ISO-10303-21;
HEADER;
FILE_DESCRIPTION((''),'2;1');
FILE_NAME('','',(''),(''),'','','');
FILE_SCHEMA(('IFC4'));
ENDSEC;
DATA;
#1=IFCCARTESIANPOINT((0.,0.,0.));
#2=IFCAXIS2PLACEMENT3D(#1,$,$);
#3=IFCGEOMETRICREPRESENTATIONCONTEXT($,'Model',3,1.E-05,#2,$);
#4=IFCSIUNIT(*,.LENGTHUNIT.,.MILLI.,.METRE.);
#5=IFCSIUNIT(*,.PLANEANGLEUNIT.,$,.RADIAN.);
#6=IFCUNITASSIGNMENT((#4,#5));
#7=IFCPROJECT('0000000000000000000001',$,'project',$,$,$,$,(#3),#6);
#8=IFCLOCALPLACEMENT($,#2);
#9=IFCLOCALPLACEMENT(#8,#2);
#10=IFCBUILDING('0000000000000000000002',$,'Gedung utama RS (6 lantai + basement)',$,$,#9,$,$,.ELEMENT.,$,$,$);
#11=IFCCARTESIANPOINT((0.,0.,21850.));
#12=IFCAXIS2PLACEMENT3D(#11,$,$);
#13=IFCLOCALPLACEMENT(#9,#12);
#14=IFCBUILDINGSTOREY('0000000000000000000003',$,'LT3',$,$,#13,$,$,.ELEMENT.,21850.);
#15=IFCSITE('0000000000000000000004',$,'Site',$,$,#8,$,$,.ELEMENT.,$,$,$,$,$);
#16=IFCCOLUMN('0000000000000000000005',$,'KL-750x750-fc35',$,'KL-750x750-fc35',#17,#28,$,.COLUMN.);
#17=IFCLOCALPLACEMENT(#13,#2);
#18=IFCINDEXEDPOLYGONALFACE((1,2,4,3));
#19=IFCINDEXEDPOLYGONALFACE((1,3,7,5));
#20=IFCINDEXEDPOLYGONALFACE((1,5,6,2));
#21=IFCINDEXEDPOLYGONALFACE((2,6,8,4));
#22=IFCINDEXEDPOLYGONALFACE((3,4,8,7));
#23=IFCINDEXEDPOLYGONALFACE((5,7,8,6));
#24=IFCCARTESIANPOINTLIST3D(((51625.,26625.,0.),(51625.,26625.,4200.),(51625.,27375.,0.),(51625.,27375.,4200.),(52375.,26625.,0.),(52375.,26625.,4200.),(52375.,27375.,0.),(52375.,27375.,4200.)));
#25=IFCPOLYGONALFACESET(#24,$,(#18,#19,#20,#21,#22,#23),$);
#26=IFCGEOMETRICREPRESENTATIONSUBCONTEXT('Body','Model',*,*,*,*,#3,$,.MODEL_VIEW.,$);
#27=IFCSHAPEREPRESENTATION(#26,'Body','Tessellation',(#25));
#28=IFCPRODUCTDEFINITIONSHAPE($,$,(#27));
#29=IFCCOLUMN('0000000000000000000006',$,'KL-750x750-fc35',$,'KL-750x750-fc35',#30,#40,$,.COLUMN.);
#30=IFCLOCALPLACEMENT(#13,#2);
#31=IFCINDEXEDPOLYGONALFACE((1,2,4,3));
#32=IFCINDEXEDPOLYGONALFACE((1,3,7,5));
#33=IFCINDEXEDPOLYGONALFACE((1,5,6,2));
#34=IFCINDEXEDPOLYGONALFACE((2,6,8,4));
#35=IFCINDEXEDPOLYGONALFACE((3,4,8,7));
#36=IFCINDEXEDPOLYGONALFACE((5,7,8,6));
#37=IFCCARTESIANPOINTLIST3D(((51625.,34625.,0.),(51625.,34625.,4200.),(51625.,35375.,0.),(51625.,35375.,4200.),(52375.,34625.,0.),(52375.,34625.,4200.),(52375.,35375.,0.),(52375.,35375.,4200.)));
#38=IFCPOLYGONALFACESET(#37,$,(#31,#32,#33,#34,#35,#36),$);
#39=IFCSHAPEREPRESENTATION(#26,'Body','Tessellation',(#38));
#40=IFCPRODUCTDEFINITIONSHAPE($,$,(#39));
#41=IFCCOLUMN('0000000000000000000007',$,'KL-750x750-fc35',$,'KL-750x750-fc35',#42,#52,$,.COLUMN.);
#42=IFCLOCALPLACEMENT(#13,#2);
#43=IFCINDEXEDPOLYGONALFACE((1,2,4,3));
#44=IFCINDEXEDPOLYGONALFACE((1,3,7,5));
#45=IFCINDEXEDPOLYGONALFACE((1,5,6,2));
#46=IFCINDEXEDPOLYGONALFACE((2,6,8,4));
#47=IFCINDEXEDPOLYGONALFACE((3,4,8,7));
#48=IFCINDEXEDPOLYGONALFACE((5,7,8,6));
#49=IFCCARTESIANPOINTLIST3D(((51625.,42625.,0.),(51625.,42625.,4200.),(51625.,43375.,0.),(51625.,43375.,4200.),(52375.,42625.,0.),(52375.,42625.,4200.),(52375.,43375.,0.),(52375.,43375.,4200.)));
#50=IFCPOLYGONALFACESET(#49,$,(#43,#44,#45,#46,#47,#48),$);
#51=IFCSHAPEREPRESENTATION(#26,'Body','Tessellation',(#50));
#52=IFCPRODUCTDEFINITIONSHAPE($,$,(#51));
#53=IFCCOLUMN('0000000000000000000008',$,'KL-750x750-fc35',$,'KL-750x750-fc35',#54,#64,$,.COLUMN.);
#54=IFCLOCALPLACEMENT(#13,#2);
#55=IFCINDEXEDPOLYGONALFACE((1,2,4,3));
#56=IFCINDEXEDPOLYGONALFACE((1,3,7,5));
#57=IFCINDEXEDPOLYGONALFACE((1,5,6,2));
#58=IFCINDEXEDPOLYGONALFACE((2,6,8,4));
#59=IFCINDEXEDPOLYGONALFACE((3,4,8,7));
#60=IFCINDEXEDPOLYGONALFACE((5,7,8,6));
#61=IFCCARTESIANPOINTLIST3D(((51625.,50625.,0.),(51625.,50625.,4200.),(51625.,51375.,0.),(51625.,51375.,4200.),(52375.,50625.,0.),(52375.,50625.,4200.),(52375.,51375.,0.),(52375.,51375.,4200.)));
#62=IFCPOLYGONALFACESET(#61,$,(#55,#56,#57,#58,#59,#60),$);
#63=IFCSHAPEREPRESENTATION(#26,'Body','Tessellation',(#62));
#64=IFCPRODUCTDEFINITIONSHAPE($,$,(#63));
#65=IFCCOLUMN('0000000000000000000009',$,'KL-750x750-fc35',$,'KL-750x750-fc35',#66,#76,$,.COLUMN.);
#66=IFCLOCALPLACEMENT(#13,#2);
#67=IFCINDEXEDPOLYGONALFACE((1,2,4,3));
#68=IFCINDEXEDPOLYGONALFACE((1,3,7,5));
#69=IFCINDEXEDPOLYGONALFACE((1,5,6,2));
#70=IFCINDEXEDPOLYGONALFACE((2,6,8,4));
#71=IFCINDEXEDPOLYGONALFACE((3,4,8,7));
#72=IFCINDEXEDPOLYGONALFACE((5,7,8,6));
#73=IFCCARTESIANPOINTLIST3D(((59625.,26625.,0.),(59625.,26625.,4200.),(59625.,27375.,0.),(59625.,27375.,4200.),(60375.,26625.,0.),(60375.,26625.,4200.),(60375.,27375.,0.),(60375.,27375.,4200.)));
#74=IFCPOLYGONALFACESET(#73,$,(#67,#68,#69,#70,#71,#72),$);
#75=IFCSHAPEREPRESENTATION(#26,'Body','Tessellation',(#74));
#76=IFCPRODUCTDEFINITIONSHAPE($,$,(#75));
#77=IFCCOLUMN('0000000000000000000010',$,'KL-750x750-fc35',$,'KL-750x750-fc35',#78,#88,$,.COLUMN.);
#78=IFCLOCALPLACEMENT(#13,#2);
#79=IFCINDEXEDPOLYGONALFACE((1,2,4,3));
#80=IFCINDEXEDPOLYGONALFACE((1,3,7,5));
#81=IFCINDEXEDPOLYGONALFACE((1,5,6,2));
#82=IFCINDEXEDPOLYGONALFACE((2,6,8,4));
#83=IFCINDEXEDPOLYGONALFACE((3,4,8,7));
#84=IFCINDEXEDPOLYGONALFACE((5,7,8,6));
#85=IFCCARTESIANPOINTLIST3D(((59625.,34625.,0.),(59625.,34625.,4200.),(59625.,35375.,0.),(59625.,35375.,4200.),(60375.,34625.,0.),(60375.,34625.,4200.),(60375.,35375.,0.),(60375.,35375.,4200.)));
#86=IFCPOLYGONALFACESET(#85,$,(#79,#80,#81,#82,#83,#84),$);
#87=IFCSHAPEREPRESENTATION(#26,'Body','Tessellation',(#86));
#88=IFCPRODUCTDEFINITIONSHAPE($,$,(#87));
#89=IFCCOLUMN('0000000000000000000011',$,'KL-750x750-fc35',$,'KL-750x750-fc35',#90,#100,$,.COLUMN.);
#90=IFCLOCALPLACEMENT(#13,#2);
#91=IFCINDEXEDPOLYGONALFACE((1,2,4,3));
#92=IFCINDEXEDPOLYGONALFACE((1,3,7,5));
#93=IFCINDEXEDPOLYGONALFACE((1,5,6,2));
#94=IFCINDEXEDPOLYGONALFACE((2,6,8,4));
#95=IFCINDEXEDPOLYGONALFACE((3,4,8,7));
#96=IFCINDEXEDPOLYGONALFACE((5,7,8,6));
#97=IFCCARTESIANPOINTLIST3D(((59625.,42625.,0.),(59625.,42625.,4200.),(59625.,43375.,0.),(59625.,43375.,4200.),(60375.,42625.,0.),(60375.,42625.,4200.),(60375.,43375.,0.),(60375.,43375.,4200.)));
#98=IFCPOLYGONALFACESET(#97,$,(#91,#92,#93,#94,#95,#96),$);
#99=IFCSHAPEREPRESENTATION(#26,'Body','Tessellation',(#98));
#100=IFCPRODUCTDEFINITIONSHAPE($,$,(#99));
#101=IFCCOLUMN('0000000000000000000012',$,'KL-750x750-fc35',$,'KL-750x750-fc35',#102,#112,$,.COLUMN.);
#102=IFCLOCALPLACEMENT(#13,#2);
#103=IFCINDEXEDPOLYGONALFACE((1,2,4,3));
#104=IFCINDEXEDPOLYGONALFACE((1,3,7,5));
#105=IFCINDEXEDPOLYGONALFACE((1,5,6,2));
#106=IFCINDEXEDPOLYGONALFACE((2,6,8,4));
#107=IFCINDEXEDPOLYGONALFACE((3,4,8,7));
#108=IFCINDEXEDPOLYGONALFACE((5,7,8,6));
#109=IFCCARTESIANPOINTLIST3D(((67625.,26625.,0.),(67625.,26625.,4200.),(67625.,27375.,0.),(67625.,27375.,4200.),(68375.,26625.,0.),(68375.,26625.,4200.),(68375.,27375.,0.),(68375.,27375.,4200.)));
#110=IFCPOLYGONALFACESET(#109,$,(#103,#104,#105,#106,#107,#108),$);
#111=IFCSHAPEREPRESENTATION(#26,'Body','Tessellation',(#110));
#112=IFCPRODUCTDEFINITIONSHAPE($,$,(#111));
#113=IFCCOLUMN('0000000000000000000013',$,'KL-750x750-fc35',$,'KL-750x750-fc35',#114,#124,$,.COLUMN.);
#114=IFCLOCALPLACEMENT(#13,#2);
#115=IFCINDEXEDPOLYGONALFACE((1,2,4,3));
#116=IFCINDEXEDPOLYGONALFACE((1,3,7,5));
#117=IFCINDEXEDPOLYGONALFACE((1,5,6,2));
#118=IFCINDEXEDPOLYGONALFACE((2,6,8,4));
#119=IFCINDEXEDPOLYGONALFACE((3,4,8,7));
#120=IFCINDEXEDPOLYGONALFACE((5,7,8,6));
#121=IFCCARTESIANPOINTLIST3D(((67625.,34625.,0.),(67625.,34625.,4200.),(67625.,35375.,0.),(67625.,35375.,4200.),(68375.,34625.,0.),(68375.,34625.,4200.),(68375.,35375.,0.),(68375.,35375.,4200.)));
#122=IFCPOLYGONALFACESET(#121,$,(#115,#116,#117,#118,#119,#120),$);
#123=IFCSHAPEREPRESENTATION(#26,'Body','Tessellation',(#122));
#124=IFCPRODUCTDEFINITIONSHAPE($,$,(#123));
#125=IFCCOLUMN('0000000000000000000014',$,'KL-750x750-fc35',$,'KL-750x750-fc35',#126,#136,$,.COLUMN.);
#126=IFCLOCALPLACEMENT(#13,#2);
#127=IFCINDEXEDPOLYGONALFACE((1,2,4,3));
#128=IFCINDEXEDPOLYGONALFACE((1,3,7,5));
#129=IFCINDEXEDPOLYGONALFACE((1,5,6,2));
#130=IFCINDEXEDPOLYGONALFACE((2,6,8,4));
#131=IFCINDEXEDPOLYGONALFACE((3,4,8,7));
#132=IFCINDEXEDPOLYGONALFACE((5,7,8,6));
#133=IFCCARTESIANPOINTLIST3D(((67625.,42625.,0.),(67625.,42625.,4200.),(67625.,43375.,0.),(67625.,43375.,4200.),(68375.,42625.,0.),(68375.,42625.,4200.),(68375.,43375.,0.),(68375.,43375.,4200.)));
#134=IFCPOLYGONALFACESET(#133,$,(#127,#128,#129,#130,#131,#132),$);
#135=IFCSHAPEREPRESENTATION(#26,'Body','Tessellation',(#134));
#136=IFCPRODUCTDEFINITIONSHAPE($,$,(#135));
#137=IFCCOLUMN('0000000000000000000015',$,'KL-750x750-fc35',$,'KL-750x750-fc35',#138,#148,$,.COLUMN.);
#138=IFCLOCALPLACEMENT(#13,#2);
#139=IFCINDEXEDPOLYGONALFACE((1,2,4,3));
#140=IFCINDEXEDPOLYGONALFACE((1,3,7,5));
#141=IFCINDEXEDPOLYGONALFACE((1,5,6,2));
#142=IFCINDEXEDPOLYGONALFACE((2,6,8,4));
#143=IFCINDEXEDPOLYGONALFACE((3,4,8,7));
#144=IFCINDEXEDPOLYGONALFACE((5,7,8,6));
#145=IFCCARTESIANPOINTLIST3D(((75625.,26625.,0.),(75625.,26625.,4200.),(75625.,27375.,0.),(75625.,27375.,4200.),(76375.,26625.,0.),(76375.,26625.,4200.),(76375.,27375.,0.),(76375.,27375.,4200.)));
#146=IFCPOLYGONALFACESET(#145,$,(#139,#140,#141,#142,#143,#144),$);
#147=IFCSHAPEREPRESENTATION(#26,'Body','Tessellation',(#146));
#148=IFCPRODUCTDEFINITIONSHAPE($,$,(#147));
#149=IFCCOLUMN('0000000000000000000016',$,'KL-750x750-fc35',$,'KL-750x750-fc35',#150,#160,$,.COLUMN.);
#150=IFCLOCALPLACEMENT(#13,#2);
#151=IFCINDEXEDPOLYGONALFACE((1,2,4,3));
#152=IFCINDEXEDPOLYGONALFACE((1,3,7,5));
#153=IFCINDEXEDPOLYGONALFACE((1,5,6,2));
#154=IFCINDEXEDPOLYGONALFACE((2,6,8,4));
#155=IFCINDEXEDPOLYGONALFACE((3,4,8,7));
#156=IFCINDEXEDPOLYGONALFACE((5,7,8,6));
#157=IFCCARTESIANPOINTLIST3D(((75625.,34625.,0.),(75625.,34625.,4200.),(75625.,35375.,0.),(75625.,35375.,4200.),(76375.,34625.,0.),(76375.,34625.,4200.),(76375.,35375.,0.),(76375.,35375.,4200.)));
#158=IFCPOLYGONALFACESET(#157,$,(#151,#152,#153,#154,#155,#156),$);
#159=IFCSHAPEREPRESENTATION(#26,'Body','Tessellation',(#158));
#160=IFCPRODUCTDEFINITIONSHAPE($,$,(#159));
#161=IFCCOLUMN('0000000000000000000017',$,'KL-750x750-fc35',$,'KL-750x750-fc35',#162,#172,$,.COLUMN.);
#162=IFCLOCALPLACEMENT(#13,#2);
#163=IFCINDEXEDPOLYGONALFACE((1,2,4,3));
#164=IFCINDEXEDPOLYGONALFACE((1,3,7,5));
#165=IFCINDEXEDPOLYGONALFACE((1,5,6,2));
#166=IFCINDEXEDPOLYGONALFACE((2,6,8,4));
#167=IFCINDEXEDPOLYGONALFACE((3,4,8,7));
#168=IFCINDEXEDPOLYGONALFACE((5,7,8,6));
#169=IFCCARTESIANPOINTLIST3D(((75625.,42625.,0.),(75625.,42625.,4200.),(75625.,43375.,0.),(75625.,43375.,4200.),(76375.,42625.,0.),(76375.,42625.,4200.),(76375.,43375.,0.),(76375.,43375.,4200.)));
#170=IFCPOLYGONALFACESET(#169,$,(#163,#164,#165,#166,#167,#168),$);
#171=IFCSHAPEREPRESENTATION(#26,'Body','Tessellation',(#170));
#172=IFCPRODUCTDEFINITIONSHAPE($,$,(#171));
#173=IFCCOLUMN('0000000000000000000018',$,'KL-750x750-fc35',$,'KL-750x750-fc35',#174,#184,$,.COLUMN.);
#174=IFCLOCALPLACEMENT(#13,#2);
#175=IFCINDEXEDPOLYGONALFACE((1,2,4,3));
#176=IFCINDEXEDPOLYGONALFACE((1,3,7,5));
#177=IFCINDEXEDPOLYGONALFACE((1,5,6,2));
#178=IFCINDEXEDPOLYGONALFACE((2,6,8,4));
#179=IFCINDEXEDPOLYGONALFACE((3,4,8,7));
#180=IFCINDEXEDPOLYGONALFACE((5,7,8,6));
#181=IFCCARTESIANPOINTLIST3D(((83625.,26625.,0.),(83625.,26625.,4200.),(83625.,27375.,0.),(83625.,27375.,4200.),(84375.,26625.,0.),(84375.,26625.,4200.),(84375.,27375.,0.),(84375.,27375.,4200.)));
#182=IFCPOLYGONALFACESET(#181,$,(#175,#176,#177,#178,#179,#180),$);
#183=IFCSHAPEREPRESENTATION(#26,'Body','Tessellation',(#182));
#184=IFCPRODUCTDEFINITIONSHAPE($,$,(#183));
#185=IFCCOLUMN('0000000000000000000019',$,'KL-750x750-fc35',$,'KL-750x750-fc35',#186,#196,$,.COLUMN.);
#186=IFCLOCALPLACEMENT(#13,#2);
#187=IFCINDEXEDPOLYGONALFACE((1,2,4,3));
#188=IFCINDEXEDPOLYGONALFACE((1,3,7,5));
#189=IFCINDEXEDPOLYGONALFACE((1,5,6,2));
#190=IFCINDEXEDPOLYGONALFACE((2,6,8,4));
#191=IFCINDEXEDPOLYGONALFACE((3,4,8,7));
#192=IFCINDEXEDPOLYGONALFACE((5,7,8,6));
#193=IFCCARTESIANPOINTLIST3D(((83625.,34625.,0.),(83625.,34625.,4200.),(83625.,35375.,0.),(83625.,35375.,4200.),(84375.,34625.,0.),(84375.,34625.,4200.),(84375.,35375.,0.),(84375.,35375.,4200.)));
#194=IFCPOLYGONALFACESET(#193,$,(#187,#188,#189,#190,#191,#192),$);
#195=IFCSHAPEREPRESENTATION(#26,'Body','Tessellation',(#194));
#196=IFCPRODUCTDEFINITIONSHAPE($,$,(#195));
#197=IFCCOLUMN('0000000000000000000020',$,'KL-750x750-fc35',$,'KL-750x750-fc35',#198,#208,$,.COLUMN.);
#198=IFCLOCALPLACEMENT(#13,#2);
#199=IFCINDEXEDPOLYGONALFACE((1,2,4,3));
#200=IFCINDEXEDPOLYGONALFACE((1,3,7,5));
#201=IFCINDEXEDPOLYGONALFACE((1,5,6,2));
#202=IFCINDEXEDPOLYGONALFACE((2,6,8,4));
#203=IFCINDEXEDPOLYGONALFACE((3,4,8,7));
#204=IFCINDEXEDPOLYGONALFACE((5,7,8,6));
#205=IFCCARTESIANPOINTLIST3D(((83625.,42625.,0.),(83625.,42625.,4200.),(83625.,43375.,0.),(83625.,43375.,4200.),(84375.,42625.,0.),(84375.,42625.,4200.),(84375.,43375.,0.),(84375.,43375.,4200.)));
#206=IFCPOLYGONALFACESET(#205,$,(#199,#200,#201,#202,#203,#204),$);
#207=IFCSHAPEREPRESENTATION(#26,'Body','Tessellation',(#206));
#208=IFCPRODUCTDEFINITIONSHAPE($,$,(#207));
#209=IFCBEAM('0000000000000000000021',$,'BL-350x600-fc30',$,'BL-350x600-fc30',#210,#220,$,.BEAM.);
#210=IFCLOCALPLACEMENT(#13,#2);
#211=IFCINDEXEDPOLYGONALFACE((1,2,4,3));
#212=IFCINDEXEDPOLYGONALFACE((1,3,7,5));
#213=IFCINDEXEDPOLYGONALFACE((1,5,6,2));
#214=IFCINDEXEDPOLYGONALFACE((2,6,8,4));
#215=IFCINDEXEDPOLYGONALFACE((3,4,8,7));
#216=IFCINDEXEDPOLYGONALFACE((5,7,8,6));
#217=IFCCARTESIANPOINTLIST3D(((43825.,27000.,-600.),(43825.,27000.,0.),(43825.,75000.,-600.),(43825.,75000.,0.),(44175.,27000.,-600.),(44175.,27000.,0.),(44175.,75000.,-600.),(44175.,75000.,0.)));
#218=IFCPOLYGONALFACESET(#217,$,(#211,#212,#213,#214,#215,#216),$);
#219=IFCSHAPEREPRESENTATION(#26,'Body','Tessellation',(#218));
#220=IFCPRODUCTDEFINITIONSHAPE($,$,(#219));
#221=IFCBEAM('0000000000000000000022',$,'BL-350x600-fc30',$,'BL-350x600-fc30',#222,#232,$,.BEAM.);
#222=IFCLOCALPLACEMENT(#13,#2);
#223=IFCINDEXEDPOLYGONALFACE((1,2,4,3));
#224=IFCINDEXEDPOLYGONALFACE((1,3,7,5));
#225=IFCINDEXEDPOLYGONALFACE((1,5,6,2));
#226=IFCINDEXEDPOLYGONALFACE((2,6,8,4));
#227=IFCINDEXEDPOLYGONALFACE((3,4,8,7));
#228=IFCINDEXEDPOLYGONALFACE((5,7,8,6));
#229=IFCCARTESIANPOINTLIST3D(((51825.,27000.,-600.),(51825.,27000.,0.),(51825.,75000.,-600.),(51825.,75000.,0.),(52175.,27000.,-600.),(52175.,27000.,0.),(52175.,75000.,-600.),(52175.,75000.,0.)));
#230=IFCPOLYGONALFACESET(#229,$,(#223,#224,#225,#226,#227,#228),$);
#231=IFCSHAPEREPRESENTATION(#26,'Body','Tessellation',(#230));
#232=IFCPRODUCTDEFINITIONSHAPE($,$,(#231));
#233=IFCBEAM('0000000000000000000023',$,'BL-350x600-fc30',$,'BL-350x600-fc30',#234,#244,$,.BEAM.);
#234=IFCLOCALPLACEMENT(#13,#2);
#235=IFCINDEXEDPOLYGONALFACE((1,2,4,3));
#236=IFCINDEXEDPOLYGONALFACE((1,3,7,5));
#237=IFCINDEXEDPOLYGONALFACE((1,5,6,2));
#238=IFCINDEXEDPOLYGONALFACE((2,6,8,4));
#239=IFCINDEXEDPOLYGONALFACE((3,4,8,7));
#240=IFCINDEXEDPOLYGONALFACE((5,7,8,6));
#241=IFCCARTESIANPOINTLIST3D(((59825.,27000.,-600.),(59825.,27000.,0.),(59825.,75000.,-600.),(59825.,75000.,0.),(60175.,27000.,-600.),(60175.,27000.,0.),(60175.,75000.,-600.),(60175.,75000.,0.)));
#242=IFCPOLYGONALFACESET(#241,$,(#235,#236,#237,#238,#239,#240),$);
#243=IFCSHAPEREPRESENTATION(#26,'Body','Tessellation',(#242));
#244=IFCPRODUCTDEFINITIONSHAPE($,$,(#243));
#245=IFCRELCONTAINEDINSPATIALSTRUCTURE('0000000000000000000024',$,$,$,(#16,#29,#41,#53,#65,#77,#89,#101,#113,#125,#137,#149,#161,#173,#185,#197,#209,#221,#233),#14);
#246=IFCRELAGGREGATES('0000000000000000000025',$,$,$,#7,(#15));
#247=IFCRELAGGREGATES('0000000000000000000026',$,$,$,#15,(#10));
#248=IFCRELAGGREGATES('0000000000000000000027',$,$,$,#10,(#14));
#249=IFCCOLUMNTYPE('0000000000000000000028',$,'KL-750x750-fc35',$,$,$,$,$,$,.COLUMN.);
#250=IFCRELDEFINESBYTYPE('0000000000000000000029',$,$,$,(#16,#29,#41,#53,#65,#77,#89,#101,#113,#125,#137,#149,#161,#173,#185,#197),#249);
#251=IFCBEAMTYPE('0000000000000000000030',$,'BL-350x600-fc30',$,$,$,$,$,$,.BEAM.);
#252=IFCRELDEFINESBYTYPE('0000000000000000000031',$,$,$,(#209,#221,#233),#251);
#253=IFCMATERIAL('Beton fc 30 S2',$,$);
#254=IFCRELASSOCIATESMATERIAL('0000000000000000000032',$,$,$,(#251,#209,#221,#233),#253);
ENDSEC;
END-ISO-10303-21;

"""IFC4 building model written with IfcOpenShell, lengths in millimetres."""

from ifc_helpers import new_model, si_unit, frame, origin, origin_2d, place, context, subcontext, project, spatial, rectangle, extrude, material, material_profile, profile_set, profile_usage, type_object, element, save


model = new_model("IFC4")

# Units and contexts
model_context = context("Model", 3, precision=1e-05, world=origin())
body_context = subcontext(model_context, "Body", "Model", "MODEL_VIEW")
ifc_project = project(units=[si_unit("LENGTHUNIT", "METRE", prefix="MILLI"), si_unit("PLANEANGLEUNIT", "RADIAN")], contexts=[model_context])

# Site, building, storey
site_placement = place(None, origin())
site = spatial("IfcSite", under=ifc_project, at=site_placement, Name="Site", CompositionType="ELEMENT")
building_placement = place(site_placement, origin())
building = spatial("IfcBuilding", under=site, at=building_placement, Name="Gedung utama RS (6 lantai + basement)", CompositionType="ELEMENT")
storey_placement = place(building_placement, frame((0.0, 0.0, 21850.0)))
storey = spatial("IfcBuildingStorey", under=building, at=storey_placement, Name="LT3", CompositionType="ELEMENT", Elevation=21850.0)

# Columns
ifc_material_profile_1 = material_profile(None, rectangle(XDim=750.0, YDim=750.0, at=origin_2d()), Name="KL-750x750-fc35")
ifc_profile_set_1 = profile_set([ifc_material_profile_1], Name="KL-750x750-fc35")
ifc_profile_usage_1 = profile_usage(ifc_profile_set_1, cardinal=5)
column_type = type_object("IfcColumnType", Name="KL-750x750-fc35", PredefinedType="COLUMN", material=ifc_profile_set_1)
for number, where, z_axis, x_axis, name in (
    (1, (52000.0, 27000.0, 0.0), (0.0, 0.0, 1.0), (1.0, 0.0, 0.0), "KL-750x750-fc35"),
    (2, (52000.0, 35000.0, 0.0), (0.0, 0.0, 1.0), (1.0, 0.0, 0.0), "KL-750x750-fc35"),
    (3, (52000.0, 43000.0, 0.0), (0.0, 0.0, 1.0), (1.0, 0.0, 0.0), "KL-750x750-fc35"),
    (4, (52000.0, 51000.0, 0.0), (0.0, 0.0, 1.0), (1.0, 0.0, 0.0), "KL-750x750-fc35"),
    (5, (60000.0, 27000.0, 0.0), (0.0, 0.0, 1.0), (1.0, 0.0, 0.0), "KL-750x750-fc35"),
    (6, (60000.0, 35000.0, 0.0), (0.0, 0.0, 1.0), (1.0, 0.0, 0.0), "KL-750x750-fc35"),
    (7, (60000.0, 43000.0, 0.0), (0.0, 0.0, 1.0), (1.0, 0.0, 0.0), "KL-750x750-fc35"),
    (8, (68000.0, 27000.0, 0.0), (0.0, 0.0, 1.0), (1.0, 0.0, 0.0), "KL-750x750-fc35"),
    (9, (68000.0, 35000.0, 0.0), (0.0, 0.0, 1.0), (1.0, 0.0, 0.0), "KL-750x750-fc35"),
    (10, (68000.0, 43000.0, 0.0), (0.0, 0.0, 1.0), (1.0, 0.0, 0.0), "KL-750x750-fc35"),
    (11, (76000.0, 27000.0, 0.0), (0.0, 0.0, 1.0), (1.0, 0.0, 0.0), "KL-750x750-fc35"),
    (12, (76000.0, 35000.0, 0.0), (0.0, 0.0, 1.0), (1.0, 0.0, 0.0), "KL-750x750-fc35"),
    (13, (76000.0, 43000.0, 0.0), (0.0, 0.0, 1.0), (1.0, 0.0, 0.0), "KL-750x750-fc35"),
    (14, (84000.0, 27000.0, 0.0), (0.0, 0.0, 1.0), (1.0, 0.0, 0.0), "KL-750x750-fc35"),
    (15, (84000.0, 35000.0, 0.0), (0.0, 0.0, 1.0), (1.0, 0.0, 0.0), "KL-750x750-fc35"),
    (16, (84000.0, 43000.0, 0.0), (0.0, 0.0, 1.0), (1.0, 0.0, 0.0), "KL-750x750-fc35"),
):
    element("IfcColumn", number, at=place(storey_placement, frame(where, z_axis=z_axis, x_axis=x_axis)), inside=storey, type_object=column_type, material=ifc_profile_usage_1, Name=name, ObjectType="KL-750x750-fc35", PredefinedType="COLUMN", context=body_context, shape_type="SweptSolid", body=[
        extrude(rectangle(XDim=750.0, YDim=750.0, at=origin_2d()), origin(), (0.0, 0.0, 1.0), 4200.0),
    ])

# Beams
ifc_material = material(Name="Beton fc 30 S2")
ifc_material_profile_2 = material_profile(ifc_material, rectangle(XDim=350.0, YDim=600.0, at=origin_2d()), Name="BL-350x600-fc30")
ifc_profile_set_2 = profile_set([ifc_material_profile_2], Name="BL-350x600-fc30")
ifc_profile_usage_2 = profile_usage(ifc_profile_set_2, cardinal=8)
beam_type = type_object("IfcBeamType", Name="BL-350x600-fc30", PredefinedType="BEAM", material=ifc_profile_set_2)
for number, where, name in (
    (17, (44000.0, 27000.0, -300.0), "BL-350x600-fc30"),
    (18, (52000.0, 27000.0, -300.0), "BL-350x600-fc30"),
    (19, (60000.0, 27000.0, -300.0), "BL-350x600-fc30"),
):
    element("IfcBeam", number, at=place(storey_placement, frame(where)), inside=storey, type_object=beam_type, material=ifc_profile_usage_2, Name=name, ObjectType="BL-350x600-fc30", PredefinedType="BEAM", context=body_context, shape_type="SweptSolid", body=[
        extrude(rectangle(XDim=350.0, YDim=600.0, at=origin_2d()), frame((0.0, 0.0, 0.0), z_axis=(0.0, 1.0, 0.0), x_axis=(-1.0, 0.0, 0.0)), (0.0, 0.0, 1.0), 48000.0),
    ])

save(model, "model.ifc")
